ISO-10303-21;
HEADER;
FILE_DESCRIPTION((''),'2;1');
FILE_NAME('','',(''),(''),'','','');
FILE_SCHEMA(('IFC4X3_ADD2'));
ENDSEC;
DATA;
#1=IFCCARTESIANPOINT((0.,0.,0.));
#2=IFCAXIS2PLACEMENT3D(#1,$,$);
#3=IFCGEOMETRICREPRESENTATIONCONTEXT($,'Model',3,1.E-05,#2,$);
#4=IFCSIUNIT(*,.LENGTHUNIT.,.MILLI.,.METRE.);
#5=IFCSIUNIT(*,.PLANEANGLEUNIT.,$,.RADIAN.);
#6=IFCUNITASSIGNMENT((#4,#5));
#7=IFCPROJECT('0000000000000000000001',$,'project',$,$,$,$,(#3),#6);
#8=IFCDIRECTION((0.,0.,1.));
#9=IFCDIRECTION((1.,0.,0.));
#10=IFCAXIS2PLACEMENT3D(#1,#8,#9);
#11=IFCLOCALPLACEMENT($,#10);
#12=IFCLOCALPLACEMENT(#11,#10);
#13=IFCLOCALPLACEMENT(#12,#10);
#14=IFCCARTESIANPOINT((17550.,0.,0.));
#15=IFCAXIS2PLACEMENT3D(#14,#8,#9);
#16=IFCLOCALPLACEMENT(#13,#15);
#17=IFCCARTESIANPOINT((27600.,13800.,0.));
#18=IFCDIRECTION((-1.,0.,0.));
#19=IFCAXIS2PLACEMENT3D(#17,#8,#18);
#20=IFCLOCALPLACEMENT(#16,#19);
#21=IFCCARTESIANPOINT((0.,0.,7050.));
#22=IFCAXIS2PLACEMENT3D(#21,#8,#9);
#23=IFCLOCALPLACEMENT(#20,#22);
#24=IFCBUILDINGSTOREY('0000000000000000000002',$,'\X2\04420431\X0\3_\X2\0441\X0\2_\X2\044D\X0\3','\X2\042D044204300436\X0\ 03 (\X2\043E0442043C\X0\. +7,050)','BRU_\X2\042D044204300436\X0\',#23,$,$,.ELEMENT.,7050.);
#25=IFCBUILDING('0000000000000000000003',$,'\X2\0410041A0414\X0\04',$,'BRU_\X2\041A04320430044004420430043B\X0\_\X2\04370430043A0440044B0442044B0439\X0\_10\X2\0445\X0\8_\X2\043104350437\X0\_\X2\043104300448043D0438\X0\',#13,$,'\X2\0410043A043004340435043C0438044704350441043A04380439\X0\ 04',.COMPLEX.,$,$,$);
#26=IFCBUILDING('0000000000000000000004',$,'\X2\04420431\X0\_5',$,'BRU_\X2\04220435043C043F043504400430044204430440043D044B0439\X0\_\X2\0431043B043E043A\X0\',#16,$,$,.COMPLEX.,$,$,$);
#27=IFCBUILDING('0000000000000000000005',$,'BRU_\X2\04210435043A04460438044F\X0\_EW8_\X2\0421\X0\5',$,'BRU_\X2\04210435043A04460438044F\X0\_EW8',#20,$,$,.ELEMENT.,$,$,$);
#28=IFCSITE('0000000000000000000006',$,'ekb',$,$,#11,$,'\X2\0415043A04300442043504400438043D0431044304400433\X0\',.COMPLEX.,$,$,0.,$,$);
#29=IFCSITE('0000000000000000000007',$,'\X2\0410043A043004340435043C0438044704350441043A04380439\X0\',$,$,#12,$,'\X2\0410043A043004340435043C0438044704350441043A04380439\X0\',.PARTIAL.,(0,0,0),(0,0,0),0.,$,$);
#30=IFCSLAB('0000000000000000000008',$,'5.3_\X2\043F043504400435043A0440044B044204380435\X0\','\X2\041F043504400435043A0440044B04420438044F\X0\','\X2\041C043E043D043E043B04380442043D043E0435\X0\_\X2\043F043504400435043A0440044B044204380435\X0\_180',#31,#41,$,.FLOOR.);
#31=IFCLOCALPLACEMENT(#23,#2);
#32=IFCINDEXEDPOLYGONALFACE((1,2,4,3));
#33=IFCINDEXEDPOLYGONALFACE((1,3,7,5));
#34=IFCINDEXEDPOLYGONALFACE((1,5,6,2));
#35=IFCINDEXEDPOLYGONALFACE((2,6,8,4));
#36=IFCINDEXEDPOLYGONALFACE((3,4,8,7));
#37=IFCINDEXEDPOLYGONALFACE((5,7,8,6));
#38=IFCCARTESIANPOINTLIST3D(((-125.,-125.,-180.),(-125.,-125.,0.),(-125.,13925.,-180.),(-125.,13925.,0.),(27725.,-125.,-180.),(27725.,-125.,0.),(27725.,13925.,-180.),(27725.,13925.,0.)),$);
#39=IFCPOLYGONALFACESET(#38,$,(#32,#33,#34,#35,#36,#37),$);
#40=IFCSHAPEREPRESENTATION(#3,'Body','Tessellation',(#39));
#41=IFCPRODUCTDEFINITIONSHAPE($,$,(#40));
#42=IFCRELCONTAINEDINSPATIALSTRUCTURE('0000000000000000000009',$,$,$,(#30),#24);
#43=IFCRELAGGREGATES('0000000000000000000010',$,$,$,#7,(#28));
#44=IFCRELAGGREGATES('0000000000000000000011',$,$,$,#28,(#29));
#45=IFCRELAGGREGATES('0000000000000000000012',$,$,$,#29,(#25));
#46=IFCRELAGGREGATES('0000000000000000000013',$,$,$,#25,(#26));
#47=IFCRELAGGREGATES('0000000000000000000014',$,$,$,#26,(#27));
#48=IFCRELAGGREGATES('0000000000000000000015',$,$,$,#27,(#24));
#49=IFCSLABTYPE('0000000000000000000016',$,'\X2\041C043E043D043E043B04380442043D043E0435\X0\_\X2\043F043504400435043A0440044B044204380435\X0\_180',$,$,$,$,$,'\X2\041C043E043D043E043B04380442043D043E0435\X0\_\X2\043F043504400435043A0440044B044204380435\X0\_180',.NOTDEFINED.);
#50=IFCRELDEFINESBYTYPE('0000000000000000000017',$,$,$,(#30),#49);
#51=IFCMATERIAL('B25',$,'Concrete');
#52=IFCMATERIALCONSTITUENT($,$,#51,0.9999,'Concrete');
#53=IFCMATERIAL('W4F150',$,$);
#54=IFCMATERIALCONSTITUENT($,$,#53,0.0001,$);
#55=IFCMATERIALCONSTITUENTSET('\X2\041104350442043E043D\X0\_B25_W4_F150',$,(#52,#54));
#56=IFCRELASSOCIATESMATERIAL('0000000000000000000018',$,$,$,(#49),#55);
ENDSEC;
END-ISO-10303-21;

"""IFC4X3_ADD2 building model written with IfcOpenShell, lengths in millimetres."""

from ifc_helpers import new_model, si_unit, frame, origin, origin_with_axes, place, context, project, spatial, polyline, outline, extrude, material, constituent, constituent_set, type_object, element, save


model = new_model("IFC4X3_ADD2")

# Units and contexts
model_context = context("Model", 3, precision=1e-05, world=origin())
ifc_project = project(units=[si_unit("LENGTHUNIT", "METRE", prefix="MILLI"), si_unit("PLANEANGLEUNIT", "RADIAN")], contexts=[model_context])

# Sites, buildings, storey
site_1_placement = place(None, origin_with_axes())
site_1 = spatial("IfcSite", under=ifc_project, at=site_1_placement, Name="ekb", LongName="Екатеринбург", CompositionType="COMPLEX", RefElevation=0.0)
site_2_placement = place(site_1_placement, origin_with_axes())
site_2 = spatial("IfcSite", under=site_1, at=site_2_placement, Name="Академический", LongName="Академический", CompositionType="PARTIAL", RefLatitude=(0, 0, 0), RefLongitude=(0, 0, 0), RefElevation=0.0)
building_1_placement = place(site_2_placement, origin_with_axes())
building_1 = spatial("IfcBuilding", under=site_2, at=building_1_placement, Name="АКД04", ObjectType="BRU_Квартал_закрытый_10х8_без_башни", LongName="Академический 04", CompositionType="COMPLEX")
building_2_placement = place(building_1_placement, frame((17550.0, 0.0, 0.0), z_axis=(0.0, 0.0, 1.0), x_axis=(1.0, 0.0, 0.0)))
building_2 = spatial("IfcBuilding", under=building_1, at=building_2_placement, Name="тб_5", ObjectType="BRU_Температурный_блок", CompositionType="COMPLEX")
building_3_placement = place(building_2_placement, frame((27600.0, 13800.0, 0.0), z_axis=(0.0, 0.0, 1.0), x_axis=(-1.0, 0.0, 0.0)))
building_3 = spatial("IfcBuilding", under=building_2, at=building_3_placement, Name="BRU_Секция_EW8_С5", ObjectType="BRU_Секция_EW8", CompositionType="ELEMENT")
storey_placement = place(building_3_placement, frame((0.0, 0.0, 7050.0), z_axis=(0.0, 0.0, 1.0), x_axis=(1.0, 0.0, 0.0)))
storey = spatial("IfcBuildingStorey", under=building_3, at=storey_placement, Name="тб3_с2_э3", Description="Этаж 03 (отм. +7,050)", ObjectType="BRU_Этаж", CompositionType="ELEMENT", Elevation=7050.0)

# Shared definitions
ifc_material_1 = material(Name="B25", Category="Concrete")
ifc_material_2 = material(Name="W4F150")

# Slab
ifc_constituent_1 = constituent(ifc_material_1, Category="Concrete", fraction=0.9999)
ifc_constituent_2 = constituent(ifc_material_2, fraction=0.0001)
ifc_constituent_set_1 = constituent_set(constituents=[ifc_constituent_1, ifc_constituent_2], Name="Бетон_B25_W4_F150")
slab_type = type_object("IfcSlabType", Name="Монолитное_перекрытие_180", ElementType="Монолитное_перекрытие_180", PredefinedType="NOTDEFINED", material=ifc_constituent_set_1)
slab_placement = place(storey_placement, frame((0.0, 0.0, -180.0), z_axis=(0.0, 0.0, 1.0), x_axis=(1.0, 0.0, 0.0)))
element("IfcSlab", 1, at=slab_placement, inside=storey, type_object=slab_type, Name="5.3_перекрытие", Description="Перекрытия", ObjectType="Монолитное_перекрытие_180", PredefinedType="FLOOR", context=model_context, shape_type="SweptSolid", body=[
    extrude(outline(polyline([(27725.0, 13925.0), (-125.0, 13925.0), (-125.0, -125.0), (27725.0, -125.0), (27725.0, 13925.0)])), origin_with_axes(), (0.0, 0.0, 1.0), 180.0),
])

save(model, "model.ifc")
